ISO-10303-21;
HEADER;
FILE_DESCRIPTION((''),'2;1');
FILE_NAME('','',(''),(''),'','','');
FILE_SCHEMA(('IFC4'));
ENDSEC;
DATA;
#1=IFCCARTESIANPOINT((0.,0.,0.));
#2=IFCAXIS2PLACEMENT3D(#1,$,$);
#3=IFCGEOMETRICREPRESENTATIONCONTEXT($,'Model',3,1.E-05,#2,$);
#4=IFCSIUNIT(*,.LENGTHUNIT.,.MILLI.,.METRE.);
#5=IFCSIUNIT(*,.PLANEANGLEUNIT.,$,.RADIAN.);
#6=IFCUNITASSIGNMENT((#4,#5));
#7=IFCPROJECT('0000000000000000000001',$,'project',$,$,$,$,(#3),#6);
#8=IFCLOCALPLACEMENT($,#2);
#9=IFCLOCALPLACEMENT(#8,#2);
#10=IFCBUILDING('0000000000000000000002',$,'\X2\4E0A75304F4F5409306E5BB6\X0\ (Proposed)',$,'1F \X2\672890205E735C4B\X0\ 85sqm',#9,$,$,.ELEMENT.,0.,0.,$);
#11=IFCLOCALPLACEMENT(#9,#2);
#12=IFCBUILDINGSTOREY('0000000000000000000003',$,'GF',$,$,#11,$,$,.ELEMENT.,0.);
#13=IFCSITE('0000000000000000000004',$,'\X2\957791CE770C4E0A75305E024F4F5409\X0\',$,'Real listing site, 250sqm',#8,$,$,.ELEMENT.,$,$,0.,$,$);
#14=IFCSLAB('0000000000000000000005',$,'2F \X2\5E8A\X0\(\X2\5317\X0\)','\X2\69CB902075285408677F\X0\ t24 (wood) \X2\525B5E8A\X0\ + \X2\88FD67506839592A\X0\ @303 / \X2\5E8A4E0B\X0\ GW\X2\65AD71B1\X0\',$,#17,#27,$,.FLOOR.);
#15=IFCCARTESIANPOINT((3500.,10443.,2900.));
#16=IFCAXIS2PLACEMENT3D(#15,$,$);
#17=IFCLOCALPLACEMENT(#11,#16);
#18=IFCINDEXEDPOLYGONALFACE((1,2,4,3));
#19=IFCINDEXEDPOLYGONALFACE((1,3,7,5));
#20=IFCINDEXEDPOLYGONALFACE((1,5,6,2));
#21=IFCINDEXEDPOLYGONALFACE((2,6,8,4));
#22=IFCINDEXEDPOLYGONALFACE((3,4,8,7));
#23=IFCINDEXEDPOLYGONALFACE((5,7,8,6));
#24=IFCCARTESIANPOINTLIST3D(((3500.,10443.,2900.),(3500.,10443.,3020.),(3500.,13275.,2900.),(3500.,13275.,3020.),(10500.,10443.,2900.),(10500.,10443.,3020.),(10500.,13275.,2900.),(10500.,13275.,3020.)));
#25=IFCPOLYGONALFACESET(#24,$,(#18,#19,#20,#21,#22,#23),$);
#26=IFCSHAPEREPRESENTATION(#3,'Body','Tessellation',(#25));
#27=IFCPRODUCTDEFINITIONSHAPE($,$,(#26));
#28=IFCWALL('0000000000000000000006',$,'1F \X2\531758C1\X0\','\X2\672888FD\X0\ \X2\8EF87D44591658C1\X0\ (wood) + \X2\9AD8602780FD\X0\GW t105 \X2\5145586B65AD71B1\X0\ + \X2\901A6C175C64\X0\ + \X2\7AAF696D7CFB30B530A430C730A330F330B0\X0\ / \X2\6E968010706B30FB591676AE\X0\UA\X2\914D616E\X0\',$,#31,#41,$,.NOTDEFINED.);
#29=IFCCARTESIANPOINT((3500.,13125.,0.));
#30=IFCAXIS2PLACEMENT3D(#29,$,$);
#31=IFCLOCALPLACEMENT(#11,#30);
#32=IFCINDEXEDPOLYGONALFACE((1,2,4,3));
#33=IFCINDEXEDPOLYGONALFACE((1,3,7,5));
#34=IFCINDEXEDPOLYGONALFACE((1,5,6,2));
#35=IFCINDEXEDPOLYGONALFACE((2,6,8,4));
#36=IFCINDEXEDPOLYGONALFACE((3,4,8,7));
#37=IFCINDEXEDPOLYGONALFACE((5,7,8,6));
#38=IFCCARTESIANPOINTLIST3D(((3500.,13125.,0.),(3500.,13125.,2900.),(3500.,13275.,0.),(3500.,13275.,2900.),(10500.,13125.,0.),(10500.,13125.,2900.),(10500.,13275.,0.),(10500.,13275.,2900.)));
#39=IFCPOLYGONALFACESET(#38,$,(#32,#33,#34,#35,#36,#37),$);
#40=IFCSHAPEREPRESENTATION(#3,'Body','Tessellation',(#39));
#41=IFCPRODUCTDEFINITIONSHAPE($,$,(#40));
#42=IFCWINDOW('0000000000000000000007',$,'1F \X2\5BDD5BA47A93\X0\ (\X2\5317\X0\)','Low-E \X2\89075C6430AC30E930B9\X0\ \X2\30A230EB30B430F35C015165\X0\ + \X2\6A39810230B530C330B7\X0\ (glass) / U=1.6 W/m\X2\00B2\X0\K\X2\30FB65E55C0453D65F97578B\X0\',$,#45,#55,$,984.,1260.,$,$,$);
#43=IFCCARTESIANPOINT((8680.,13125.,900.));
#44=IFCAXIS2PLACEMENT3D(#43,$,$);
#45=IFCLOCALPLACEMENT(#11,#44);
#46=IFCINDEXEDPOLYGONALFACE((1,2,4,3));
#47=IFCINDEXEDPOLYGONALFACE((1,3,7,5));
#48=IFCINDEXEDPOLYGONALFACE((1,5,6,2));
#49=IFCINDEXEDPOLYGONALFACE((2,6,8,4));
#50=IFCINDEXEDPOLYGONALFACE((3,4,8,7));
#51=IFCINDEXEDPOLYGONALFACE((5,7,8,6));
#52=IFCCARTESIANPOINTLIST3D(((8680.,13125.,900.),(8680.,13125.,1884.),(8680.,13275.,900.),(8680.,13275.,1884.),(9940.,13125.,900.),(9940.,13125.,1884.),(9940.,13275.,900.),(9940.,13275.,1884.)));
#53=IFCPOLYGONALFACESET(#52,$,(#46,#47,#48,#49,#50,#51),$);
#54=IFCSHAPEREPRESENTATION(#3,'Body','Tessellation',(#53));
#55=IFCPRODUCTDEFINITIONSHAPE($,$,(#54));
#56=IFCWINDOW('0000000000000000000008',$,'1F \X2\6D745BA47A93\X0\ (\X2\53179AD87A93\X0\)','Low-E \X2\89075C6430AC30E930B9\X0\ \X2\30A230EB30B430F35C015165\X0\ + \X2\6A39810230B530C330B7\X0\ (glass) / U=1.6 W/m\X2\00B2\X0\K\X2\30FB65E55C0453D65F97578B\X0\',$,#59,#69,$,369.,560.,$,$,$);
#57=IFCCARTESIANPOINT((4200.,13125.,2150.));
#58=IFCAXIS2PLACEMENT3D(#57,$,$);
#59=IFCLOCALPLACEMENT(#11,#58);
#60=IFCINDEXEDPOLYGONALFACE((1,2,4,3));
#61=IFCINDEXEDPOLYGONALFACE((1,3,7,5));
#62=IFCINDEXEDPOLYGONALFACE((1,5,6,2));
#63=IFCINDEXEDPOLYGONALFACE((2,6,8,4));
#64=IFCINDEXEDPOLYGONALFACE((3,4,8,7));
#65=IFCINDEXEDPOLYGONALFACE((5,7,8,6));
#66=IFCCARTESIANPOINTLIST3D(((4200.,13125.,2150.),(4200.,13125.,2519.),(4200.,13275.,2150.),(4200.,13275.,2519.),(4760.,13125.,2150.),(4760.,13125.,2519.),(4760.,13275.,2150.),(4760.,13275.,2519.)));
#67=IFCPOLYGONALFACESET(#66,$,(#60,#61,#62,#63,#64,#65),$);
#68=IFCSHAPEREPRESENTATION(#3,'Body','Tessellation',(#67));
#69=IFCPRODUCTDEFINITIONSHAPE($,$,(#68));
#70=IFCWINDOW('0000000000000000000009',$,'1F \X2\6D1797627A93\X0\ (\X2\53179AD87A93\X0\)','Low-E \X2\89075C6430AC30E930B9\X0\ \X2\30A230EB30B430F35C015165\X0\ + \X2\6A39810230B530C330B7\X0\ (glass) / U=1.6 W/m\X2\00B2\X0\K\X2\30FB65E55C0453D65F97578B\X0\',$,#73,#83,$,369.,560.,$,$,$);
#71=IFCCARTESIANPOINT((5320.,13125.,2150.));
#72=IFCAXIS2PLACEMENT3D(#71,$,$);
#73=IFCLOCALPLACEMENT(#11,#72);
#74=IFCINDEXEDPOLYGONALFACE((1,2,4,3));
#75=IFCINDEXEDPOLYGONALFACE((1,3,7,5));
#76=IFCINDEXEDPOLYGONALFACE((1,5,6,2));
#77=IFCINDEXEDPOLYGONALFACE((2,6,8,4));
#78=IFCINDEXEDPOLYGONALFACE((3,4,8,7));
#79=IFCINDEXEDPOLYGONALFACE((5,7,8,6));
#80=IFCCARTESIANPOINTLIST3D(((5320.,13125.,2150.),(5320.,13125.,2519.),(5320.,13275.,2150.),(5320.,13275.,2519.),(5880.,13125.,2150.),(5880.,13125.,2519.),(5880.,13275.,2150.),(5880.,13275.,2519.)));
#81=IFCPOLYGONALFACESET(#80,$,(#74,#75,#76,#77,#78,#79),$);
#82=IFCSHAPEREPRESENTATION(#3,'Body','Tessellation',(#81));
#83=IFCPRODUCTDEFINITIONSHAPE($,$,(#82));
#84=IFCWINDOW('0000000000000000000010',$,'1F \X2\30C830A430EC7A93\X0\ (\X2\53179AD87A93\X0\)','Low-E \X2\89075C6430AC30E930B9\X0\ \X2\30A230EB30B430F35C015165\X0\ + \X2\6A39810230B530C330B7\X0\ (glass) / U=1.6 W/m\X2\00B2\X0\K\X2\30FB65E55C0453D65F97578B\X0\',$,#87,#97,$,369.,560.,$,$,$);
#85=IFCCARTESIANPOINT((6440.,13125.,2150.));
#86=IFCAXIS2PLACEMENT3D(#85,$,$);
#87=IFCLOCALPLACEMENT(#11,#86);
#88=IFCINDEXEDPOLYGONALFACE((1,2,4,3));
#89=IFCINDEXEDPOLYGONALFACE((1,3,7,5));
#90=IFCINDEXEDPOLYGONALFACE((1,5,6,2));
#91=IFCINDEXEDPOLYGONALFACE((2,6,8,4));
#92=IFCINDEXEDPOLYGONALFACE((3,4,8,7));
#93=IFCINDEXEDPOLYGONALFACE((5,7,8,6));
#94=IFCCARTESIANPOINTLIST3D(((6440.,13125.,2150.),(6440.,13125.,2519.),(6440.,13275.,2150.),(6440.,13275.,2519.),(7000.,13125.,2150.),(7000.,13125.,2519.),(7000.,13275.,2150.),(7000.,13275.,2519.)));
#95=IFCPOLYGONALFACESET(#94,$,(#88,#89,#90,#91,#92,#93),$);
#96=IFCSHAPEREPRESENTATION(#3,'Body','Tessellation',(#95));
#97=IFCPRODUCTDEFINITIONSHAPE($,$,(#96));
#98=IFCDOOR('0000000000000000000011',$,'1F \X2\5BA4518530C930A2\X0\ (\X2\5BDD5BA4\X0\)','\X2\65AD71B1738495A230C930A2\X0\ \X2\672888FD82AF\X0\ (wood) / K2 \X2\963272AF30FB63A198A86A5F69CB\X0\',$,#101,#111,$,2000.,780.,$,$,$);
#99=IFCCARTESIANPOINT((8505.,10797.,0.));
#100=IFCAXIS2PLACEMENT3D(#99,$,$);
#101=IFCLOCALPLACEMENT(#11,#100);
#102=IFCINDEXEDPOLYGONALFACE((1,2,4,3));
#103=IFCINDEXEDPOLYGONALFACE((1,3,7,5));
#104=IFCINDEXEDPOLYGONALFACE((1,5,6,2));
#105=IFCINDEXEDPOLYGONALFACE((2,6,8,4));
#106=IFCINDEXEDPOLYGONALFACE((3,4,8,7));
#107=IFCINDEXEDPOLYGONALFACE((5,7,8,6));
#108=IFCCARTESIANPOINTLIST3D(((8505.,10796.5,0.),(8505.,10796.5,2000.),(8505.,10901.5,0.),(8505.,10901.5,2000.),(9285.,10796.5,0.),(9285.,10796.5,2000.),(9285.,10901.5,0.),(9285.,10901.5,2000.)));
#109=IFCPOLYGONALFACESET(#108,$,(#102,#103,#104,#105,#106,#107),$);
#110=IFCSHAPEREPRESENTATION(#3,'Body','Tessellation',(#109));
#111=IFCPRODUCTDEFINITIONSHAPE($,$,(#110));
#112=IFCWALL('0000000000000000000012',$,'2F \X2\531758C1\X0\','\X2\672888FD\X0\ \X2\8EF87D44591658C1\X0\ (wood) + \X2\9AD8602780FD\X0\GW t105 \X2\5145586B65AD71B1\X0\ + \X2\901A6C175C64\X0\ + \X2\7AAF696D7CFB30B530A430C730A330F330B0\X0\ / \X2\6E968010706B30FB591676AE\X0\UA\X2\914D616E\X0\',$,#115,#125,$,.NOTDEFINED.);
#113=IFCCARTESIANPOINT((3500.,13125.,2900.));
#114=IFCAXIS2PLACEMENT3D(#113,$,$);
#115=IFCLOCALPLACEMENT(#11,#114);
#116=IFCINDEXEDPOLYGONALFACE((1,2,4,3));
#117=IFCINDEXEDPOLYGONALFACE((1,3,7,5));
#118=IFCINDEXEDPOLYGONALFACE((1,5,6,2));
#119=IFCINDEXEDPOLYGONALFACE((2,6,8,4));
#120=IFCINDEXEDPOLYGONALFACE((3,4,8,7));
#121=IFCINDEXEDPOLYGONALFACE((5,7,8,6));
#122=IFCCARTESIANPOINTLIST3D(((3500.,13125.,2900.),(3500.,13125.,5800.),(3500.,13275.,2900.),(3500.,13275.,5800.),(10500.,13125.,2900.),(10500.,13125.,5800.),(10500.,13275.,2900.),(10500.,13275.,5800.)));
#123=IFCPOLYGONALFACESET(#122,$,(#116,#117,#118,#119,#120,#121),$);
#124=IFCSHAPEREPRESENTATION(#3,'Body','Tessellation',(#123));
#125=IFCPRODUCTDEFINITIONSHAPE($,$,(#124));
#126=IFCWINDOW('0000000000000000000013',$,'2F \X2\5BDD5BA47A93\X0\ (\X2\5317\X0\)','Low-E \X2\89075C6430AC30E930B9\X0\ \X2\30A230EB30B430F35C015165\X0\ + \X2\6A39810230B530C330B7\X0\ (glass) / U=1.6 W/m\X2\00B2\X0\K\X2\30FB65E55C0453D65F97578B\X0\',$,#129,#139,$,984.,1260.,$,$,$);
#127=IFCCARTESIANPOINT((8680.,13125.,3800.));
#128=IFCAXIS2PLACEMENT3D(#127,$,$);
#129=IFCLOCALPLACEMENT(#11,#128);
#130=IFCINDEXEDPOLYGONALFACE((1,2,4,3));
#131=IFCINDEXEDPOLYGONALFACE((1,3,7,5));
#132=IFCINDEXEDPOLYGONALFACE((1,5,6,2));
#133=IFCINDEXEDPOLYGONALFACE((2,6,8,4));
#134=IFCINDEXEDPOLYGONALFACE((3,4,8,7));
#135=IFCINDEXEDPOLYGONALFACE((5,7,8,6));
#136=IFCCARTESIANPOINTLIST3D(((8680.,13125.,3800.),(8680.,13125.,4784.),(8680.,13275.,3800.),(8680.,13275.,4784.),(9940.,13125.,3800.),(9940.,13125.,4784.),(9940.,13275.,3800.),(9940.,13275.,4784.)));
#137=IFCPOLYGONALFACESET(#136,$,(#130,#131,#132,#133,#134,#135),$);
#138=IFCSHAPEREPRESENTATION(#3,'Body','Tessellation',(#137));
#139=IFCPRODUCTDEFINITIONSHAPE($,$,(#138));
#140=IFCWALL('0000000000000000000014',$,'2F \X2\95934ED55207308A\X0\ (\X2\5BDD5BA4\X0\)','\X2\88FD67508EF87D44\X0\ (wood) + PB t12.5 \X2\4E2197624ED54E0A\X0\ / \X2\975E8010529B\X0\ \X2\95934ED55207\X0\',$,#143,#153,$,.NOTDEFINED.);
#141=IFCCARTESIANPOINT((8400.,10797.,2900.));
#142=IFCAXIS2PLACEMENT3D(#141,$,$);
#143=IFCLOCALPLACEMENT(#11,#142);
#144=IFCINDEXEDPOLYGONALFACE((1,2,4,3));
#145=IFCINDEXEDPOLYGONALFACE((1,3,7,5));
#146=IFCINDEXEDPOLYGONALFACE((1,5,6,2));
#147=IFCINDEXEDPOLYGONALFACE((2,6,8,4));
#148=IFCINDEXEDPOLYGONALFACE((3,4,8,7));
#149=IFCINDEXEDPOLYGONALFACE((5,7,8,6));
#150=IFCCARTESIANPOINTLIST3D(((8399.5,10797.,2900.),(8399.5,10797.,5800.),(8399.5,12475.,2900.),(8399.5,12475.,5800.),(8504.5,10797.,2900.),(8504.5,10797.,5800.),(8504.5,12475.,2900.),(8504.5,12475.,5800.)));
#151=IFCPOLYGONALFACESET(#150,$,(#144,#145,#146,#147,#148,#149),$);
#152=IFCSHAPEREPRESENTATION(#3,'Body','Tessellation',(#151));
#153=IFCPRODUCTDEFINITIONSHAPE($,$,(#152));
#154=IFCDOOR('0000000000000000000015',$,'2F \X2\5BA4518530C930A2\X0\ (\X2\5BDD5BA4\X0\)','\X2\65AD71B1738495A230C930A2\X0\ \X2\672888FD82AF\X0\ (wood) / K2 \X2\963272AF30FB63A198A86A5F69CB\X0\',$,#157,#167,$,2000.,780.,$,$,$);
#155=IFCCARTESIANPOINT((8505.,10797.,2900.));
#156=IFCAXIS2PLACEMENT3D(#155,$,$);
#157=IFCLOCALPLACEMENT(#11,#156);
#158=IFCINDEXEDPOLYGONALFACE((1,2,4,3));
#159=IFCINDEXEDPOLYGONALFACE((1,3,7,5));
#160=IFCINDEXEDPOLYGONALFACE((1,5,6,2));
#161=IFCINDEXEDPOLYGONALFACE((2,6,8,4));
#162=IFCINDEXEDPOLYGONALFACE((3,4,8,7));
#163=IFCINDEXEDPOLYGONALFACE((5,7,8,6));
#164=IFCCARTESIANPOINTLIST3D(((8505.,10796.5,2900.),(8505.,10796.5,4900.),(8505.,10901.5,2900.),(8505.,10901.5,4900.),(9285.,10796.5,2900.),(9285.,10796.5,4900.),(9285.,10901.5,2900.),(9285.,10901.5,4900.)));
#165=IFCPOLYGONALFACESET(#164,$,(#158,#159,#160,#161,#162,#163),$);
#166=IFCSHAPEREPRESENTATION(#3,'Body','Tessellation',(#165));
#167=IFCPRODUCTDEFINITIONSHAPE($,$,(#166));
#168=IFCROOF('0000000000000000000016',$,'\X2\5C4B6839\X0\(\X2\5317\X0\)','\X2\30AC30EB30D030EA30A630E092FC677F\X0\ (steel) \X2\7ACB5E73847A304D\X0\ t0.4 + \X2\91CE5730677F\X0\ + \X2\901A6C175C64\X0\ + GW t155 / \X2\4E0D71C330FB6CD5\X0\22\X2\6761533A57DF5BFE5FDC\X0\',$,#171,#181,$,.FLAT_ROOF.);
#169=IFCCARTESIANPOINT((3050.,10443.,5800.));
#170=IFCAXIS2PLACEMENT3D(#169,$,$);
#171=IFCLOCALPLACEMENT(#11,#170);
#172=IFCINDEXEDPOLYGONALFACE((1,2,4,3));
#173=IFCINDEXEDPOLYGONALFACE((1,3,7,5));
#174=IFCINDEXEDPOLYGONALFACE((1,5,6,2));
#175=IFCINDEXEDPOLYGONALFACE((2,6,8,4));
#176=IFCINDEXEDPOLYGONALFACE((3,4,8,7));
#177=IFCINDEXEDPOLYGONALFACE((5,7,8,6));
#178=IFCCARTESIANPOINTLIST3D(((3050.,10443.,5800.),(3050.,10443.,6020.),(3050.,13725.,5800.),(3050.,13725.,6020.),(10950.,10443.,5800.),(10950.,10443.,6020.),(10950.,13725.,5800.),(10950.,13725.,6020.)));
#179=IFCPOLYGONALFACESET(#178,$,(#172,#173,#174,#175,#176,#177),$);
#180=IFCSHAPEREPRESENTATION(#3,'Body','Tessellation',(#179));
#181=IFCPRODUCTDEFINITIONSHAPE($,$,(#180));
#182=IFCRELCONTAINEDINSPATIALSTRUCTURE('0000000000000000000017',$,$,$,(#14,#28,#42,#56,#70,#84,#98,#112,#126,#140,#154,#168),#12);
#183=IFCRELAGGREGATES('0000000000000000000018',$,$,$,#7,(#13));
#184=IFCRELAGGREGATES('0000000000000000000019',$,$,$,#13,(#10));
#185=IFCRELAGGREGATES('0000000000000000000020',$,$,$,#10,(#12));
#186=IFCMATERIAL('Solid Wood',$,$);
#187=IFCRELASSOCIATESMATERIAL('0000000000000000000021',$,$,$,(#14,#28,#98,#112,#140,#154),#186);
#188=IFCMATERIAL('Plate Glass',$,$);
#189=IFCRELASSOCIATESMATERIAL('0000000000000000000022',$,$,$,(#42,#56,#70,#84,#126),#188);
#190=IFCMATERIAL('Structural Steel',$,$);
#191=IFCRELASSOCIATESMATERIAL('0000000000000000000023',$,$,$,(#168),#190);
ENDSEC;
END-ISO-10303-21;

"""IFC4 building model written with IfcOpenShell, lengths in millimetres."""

from ifc_helpers import new_model, si_unit, frame, frame_2d, origin, place, context, project, spatial, rectangle, extrude, material, element, fill, save


model = new_model("IFC4")

# Units and contexts
model_context = context("Model", 3, precision=1e-05, world=origin())
ifc_project = project(units=[si_unit("LENGTHUNIT", "METRE", prefix="MILLI"), si_unit("PLANEANGLEUNIT", "RADIAN")], contexts=[model_context])

# Site, building, storey
site_placement = place(None, origin())
site = spatial("IfcSite", under=ifc_project, at=site_placement, Name="長野県上田市住吉", ObjectType="Real listing site, 250sqm", CompositionType="ELEMENT", RefElevation=0.0)
building_placement = place(site_placement, origin())
building = spatial("IfcBuilding", under=site, at=building_placement, Name="上田住吉の家 (Proposed)", ObjectType="1F 木造平屋 85sqm", CompositionType="ELEMENT", ElevationOfRefHeight=0.0, ElevationOfTerrain=0.0)
storey_placement = place(building_placement, origin())
storey = spatial("IfcBuildingStorey", under=building, at=storey_placement, Name="GF", CompositionType="ELEMENT", Elevation=0.0)

# Slab
ifc_material_1 = material(Name="Solid Wood")
slab_placement = place(storey_placement, frame((3500.0, 10443.0, 2900.0)))
element("IfcSlab", 1, at=slab_placement, inside=storey, material=ifc_material_1, Name="2F 床(北)", Description="構造用合板 t24 (wood) 剛床 + 製材根太 @303 / 床下 GW断熱", PredefinedType="FLOOR", context=model_context, shape_type="SweptSolid", body=[
    extrude(rectangle(XDim=7000.0, YDim=2832.0, at=frame_2d((3500.0, 1416.0))), frame((3500.0, 10443.0, 2900.0)), (0.0, 0.0, 1.0), 120.0),
])

# Wall, openings, windows
wall_1_placement = place(storey_placement, frame((3500.0, 13125.0, 0.0)))
wall_1 = element("IfcWall", 2, at=wall_1_placement, inside=storey, material=ifc_material_1, Name="1F 北壁", Description="木製 軸組外壁 (wood) + 高性能GW t105 充填断熱 + 通気層 + 窯業系サイディング / 準耐火・外皮UA配慮", PredefinedType="NOTDEFINED", context=model_context, shape_type="SweptSolid", body=[
    extrude(rectangle(XDim=7000.0, YDim=150.0, at=frame_2d((3500.0, 75.0))), frame((3500.0, 13125.0, 0.0)), (0.0, 0.0, 1.0), 2900.0),
])
opening_1_placement = place(storey_placement, frame((8680.0, 13125.0, 900.0)))
opening_1 = element("IfcOpeningElement", 3, at=opening_1_placement, cuts=wall_1, PredefinedType="NOTDEFINED", context=model_context, shape_type="SweptSolid", body=[
    extrude(rectangle(XDim=1260.0, YDim=150.0, at=frame_2d((630.0, 75.0))), frame((8680.0, 13125.0, 900.0)), (0.0, 0.0, 1.0), 984.0),
])
opening_2_placement = place(storey_placement, frame((4200.0, 13125.0, 2150.0)))
opening_2 = element("IfcOpeningElement", 4, at=opening_2_placement, cuts=wall_1, PredefinedType="NOTDEFINED", context=model_context, shape_type="SweptSolid", body=[
    extrude(rectangle(XDim=560.0, YDim=150.0, at=frame_2d((280.0, 75.0))), frame((4200.0, 13125.0, 2150.0)), (0.0, 0.0, 1.0), 369.0),
])
opening_3_placement = place(storey_placement, frame((5320.0, 13125.0, 2150.0)))
opening_3 = element("IfcOpeningElement", 5, at=opening_3_placement, cuts=wall_1, PredefinedType="NOTDEFINED", context=model_context, shape_type="SweptSolid", body=[
    extrude(rectangle(XDim=560.0, YDim=150.0, at=frame_2d((280.0, 75.0))), frame((5320.0, 13125.0, 2150.0)), (0.0, 0.0, 1.0), 369.0),
])
opening_4_placement = place(storey_placement, frame((6440.0, 13125.0, 2150.0)))
opening_4 = element("IfcOpeningElement", 6, at=opening_4_placement, cuts=wall_1, PredefinedType="NOTDEFINED", context=model_context, shape_type="SweptSolid", body=[
    extrude(rectangle(XDim=560.0, YDim=150.0, at=frame_2d((280.0, 75.0))), frame((6440.0, 13125.0, 2150.0)), (0.0, 0.0, 1.0), 369.0),
])
ifc_material_2 = material(Name="Plate Glass")
window_1_placement = place(storey_placement, frame((8680.0, 13125.0, 900.0)))
window_1 = element("IfcWindow", 7, at=window_1_placement, inside=storey, material=ifc_material_2, Name="1F 寝室窓 (北)", Description="Low-E 複層ガラス アルゴン封入 + 樹脂サッシ (glass) / U=1.6 W/m²K・日射取得型", OverallHeight=984.0, OverallWidth=1260.0, context=model_context, shape_type="SweptSolid", body=[
    extrude(rectangle(XDim=1260.0, YDim=150.0, at=frame_2d((630.0, 75.0))), frame((8680.0, 13125.0, 900.0)), (0.0, 0.0, 1.0), 984.0),
])
fill(opening_1, window_1)
window_2_placement = place(storey_placement, frame((4200.0, 13125.0, 2150.0)))
window_2 = element("IfcWindow", 8, at=window_2_placement, inside=storey, material=ifc_material_2, Name="1F 浴室窓 (北高窓)", Description="Low-E 複層ガラス アルゴン封入 + 樹脂サッシ (glass) / U=1.6 W/m²K・日射取得型", OverallHeight=369.0, OverallWidth=560.0, context=model_context, shape_type="SweptSolid", body=[
    extrude(rectangle(XDim=560.0, YDim=150.0, at=frame_2d((280.0, 75.0))), frame((4200.0, 13125.0, 2150.0)), (0.0, 0.0, 1.0), 369.0),
])
fill(opening_2, window_2)
window_3_placement = place(storey_placement, frame((5320.0, 13125.0, 2150.0)))
window_3 = element("IfcWindow", 9, at=window_3_placement, inside=storey, material=ifc_material_2, Name="1F 洗面窓 (北高窓)", Description="Low-E 複層ガラス アルゴン封入 + 樹脂サッシ (glass) / U=1.6 W/m²K・日射取得型", OverallHeight=369.0, OverallWidth=560.0, context=model_context, shape_type="SweptSolid", body=[
    extrude(rectangle(XDim=560.0, YDim=150.0, at=frame_2d((280.0, 75.0))), frame((5320.0, 13125.0, 2150.0)), (0.0, 0.0, 1.0), 369.0),
])
fill(opening_3, window_3)
window_4_placement = place(storey_placement, frame((6440.0, 13125.0, 2150.0)))
window_4 = element("IfcWindow", 10, at=window_4_placement, inside=storey, material=ifc_material_2, Name="1F トイレ窓 (北高窓)", Description="Low-E 複層ガラス アルゴン封入 + 樹脂サッシ (glass) / U=1.6 W/m²K・日射取得型", OverallHeight=369.0, OverallWidth=560.0, context=model_context, shape_type="SweptSolid", body=[
    extrude(rectangle(XDim=560.0, YDim=150.0, at=frame_2d((280.0, 75.0))), frame((6440.0, 13125.0, 2150.0)), (0.0, 0.0, 1.0), 369.0),
])
fill(opening_4, window_4)

# Door
door_1_placement = place(storey_placement, frame((8505.0, 10797.0, 0.0)))
element("IfcDoor", 11, at=door_1_placement, inside=storey, material=ifc_material_1, Name="1F 室内ドア (寝室)", Description="断熱玄関ドア 木製芯 (wood) / K2 防犯・採風機構", OverallHeight=2000.0, OverallWidth=780.0, context=model_context, shape_type="SweptSolid", body=[
    extrude(rectangle(XDim=780.0, YDim=105.0, at=frame_2d((390.0, 52.0))), frame((8505.0, 10797.0, 0.0)), (0.0, 0.0, 1.0), 2000.0),
])

# Wall, opening, window
wall_2_placement = place(storey_placement, frame((3500.0, 13125.0, 2900.0)))
wall_2 = element("IfcWall", 12, at=wall_2_placement, inside=storey, material=ifc_material_1, Name="2F 北壁", Description="木製 軸組外壁 (wood) + 高性能GW t105 充填断熱 + 通気層 + 窯業系サイディング / 準耐火・外皮UA配慮", PredefinedType="NOTDEFINED", context=model_context, shape_type="SweptSolid", body=[
    extrude(rectangle(XDim=7000.0, YDim=150.0, at=frame_2d((3500.0, 75.0))), frame((3500.0, 13125.0, 2900.0)), (0.0, 0.0, 1.0), 2900.0),
])
opening_5_placement = place(storey_placement, frame((8680.0, 13125.0, 3800.0)))
opening_5 = element("IfcOpeningElement", 13, at=opening_5_placement, cuts=wall_2, PredefinedType="NOTDEFINED", context=model_context, shape_type="SweptSolid", body=[
    extrude(rectangle(XDim=1260.0, YDim=150.0, at=frame_2d((630.0, 75.0))), frame((8680.0, 13125.0, 3800.0)), (0.0, 0.0, 1.0), 984.0),
])
window_5_placement = place(storey_placement, frame((8680.0, 13125.0, 3800.0)))
window_5 = element("IfcWindow", 14, at=window_5_placement, inside=storey, material=ifc_material_2, Name="2F 寝室窓 (北)", Description="Low-E 複層ガラス アルゴン封入 + 樹脂サッシ (glass) / U=1.6 W/m²K・日射取得型", OverallHeight=984.0, OverallWidth=1260.0, context=model_context, shape_type="SweptSolid", body=[
    extrude(rectangle(XDim=1260.0, YDim=150.0, at=frame_2d((630.0, 75.0))), frame((8680.0, 13125.0, 3800.0)), (0.0, 0.0, 1.0), 984.0),
])
fill(opening_5, window_5)

# Wall
wall_3_placement = place(storey_placement, frame((8400.0, 10797.0, 2900.0)))
element("IfcWall", 15, at=wall_3_placement, inside=storey, material=ifc_material_1, Name="2F 間仕切り (寝室)", Description="製材軸組 (wood) + PB t12.5 両面仕上 / 非耐力 間仕切", PredefinedType="NOTDEFINED", context=model_context, shape_type="SweptSolid", body=[
    extrude(rectangle(XDim=105.0, YDim=1678.0, at=frame_2d((52.0, 839.0))), frame((8400.0, 10797.0, 2900.0)), (0.0, 0.0, 1.0), 2900.0),
])

# Door
door_2_placement = place(storey_placement, frame((8505.0, 10797.0, 2900.0)))
element("IfcDoor", 16, at=door_2_placement, inside=storey, material=ifc_material_1, Name="2F 室内ドア (寝室)", Description="断熱玄関ドア 木製芯 (wood) / K2 防犯・採風機構", OverallHeight=2000.0, OverallWidth=780.0, context=model_context, shape_type="SweptSolid", body=[
    extrude(rectangle(XDim=780.0, YDim=105.0, at=frame_2d((390.0, 52.0))), frame((8505.0, 10797.0, 2900.0)), (0.0, 0.0, 1.0), 2000.0),
])

# Roof
ifc_material_3 = material(Name="Structural Steel")
roof_placement = place(storey_placement, frame((3050.0, 10443.0, 5800.0)))
element("IfcRoof", 17, at=roof_placement, inside=storey, material=ifc_material_3, Name="屋根(北)", Description="ガルバリウム鋼板 (steel) 立平葺き t0.4 + 野地板 + 通気層 + GW t155 / 不燃・法22条区域対応", PredefinedType="FLAT_ROOF", context=model_context, shape_type="SweptSolid", body=[
    extrude(rectangle(XDim=7900.0, YDim=3282.0, at=frame_2d((3950.0, 1641.0))), frame((3050.0, 10443.0, 5800.0)), (0.0, 0.0, 1.0), 220.0),
])

save(model, "model.ifc")
